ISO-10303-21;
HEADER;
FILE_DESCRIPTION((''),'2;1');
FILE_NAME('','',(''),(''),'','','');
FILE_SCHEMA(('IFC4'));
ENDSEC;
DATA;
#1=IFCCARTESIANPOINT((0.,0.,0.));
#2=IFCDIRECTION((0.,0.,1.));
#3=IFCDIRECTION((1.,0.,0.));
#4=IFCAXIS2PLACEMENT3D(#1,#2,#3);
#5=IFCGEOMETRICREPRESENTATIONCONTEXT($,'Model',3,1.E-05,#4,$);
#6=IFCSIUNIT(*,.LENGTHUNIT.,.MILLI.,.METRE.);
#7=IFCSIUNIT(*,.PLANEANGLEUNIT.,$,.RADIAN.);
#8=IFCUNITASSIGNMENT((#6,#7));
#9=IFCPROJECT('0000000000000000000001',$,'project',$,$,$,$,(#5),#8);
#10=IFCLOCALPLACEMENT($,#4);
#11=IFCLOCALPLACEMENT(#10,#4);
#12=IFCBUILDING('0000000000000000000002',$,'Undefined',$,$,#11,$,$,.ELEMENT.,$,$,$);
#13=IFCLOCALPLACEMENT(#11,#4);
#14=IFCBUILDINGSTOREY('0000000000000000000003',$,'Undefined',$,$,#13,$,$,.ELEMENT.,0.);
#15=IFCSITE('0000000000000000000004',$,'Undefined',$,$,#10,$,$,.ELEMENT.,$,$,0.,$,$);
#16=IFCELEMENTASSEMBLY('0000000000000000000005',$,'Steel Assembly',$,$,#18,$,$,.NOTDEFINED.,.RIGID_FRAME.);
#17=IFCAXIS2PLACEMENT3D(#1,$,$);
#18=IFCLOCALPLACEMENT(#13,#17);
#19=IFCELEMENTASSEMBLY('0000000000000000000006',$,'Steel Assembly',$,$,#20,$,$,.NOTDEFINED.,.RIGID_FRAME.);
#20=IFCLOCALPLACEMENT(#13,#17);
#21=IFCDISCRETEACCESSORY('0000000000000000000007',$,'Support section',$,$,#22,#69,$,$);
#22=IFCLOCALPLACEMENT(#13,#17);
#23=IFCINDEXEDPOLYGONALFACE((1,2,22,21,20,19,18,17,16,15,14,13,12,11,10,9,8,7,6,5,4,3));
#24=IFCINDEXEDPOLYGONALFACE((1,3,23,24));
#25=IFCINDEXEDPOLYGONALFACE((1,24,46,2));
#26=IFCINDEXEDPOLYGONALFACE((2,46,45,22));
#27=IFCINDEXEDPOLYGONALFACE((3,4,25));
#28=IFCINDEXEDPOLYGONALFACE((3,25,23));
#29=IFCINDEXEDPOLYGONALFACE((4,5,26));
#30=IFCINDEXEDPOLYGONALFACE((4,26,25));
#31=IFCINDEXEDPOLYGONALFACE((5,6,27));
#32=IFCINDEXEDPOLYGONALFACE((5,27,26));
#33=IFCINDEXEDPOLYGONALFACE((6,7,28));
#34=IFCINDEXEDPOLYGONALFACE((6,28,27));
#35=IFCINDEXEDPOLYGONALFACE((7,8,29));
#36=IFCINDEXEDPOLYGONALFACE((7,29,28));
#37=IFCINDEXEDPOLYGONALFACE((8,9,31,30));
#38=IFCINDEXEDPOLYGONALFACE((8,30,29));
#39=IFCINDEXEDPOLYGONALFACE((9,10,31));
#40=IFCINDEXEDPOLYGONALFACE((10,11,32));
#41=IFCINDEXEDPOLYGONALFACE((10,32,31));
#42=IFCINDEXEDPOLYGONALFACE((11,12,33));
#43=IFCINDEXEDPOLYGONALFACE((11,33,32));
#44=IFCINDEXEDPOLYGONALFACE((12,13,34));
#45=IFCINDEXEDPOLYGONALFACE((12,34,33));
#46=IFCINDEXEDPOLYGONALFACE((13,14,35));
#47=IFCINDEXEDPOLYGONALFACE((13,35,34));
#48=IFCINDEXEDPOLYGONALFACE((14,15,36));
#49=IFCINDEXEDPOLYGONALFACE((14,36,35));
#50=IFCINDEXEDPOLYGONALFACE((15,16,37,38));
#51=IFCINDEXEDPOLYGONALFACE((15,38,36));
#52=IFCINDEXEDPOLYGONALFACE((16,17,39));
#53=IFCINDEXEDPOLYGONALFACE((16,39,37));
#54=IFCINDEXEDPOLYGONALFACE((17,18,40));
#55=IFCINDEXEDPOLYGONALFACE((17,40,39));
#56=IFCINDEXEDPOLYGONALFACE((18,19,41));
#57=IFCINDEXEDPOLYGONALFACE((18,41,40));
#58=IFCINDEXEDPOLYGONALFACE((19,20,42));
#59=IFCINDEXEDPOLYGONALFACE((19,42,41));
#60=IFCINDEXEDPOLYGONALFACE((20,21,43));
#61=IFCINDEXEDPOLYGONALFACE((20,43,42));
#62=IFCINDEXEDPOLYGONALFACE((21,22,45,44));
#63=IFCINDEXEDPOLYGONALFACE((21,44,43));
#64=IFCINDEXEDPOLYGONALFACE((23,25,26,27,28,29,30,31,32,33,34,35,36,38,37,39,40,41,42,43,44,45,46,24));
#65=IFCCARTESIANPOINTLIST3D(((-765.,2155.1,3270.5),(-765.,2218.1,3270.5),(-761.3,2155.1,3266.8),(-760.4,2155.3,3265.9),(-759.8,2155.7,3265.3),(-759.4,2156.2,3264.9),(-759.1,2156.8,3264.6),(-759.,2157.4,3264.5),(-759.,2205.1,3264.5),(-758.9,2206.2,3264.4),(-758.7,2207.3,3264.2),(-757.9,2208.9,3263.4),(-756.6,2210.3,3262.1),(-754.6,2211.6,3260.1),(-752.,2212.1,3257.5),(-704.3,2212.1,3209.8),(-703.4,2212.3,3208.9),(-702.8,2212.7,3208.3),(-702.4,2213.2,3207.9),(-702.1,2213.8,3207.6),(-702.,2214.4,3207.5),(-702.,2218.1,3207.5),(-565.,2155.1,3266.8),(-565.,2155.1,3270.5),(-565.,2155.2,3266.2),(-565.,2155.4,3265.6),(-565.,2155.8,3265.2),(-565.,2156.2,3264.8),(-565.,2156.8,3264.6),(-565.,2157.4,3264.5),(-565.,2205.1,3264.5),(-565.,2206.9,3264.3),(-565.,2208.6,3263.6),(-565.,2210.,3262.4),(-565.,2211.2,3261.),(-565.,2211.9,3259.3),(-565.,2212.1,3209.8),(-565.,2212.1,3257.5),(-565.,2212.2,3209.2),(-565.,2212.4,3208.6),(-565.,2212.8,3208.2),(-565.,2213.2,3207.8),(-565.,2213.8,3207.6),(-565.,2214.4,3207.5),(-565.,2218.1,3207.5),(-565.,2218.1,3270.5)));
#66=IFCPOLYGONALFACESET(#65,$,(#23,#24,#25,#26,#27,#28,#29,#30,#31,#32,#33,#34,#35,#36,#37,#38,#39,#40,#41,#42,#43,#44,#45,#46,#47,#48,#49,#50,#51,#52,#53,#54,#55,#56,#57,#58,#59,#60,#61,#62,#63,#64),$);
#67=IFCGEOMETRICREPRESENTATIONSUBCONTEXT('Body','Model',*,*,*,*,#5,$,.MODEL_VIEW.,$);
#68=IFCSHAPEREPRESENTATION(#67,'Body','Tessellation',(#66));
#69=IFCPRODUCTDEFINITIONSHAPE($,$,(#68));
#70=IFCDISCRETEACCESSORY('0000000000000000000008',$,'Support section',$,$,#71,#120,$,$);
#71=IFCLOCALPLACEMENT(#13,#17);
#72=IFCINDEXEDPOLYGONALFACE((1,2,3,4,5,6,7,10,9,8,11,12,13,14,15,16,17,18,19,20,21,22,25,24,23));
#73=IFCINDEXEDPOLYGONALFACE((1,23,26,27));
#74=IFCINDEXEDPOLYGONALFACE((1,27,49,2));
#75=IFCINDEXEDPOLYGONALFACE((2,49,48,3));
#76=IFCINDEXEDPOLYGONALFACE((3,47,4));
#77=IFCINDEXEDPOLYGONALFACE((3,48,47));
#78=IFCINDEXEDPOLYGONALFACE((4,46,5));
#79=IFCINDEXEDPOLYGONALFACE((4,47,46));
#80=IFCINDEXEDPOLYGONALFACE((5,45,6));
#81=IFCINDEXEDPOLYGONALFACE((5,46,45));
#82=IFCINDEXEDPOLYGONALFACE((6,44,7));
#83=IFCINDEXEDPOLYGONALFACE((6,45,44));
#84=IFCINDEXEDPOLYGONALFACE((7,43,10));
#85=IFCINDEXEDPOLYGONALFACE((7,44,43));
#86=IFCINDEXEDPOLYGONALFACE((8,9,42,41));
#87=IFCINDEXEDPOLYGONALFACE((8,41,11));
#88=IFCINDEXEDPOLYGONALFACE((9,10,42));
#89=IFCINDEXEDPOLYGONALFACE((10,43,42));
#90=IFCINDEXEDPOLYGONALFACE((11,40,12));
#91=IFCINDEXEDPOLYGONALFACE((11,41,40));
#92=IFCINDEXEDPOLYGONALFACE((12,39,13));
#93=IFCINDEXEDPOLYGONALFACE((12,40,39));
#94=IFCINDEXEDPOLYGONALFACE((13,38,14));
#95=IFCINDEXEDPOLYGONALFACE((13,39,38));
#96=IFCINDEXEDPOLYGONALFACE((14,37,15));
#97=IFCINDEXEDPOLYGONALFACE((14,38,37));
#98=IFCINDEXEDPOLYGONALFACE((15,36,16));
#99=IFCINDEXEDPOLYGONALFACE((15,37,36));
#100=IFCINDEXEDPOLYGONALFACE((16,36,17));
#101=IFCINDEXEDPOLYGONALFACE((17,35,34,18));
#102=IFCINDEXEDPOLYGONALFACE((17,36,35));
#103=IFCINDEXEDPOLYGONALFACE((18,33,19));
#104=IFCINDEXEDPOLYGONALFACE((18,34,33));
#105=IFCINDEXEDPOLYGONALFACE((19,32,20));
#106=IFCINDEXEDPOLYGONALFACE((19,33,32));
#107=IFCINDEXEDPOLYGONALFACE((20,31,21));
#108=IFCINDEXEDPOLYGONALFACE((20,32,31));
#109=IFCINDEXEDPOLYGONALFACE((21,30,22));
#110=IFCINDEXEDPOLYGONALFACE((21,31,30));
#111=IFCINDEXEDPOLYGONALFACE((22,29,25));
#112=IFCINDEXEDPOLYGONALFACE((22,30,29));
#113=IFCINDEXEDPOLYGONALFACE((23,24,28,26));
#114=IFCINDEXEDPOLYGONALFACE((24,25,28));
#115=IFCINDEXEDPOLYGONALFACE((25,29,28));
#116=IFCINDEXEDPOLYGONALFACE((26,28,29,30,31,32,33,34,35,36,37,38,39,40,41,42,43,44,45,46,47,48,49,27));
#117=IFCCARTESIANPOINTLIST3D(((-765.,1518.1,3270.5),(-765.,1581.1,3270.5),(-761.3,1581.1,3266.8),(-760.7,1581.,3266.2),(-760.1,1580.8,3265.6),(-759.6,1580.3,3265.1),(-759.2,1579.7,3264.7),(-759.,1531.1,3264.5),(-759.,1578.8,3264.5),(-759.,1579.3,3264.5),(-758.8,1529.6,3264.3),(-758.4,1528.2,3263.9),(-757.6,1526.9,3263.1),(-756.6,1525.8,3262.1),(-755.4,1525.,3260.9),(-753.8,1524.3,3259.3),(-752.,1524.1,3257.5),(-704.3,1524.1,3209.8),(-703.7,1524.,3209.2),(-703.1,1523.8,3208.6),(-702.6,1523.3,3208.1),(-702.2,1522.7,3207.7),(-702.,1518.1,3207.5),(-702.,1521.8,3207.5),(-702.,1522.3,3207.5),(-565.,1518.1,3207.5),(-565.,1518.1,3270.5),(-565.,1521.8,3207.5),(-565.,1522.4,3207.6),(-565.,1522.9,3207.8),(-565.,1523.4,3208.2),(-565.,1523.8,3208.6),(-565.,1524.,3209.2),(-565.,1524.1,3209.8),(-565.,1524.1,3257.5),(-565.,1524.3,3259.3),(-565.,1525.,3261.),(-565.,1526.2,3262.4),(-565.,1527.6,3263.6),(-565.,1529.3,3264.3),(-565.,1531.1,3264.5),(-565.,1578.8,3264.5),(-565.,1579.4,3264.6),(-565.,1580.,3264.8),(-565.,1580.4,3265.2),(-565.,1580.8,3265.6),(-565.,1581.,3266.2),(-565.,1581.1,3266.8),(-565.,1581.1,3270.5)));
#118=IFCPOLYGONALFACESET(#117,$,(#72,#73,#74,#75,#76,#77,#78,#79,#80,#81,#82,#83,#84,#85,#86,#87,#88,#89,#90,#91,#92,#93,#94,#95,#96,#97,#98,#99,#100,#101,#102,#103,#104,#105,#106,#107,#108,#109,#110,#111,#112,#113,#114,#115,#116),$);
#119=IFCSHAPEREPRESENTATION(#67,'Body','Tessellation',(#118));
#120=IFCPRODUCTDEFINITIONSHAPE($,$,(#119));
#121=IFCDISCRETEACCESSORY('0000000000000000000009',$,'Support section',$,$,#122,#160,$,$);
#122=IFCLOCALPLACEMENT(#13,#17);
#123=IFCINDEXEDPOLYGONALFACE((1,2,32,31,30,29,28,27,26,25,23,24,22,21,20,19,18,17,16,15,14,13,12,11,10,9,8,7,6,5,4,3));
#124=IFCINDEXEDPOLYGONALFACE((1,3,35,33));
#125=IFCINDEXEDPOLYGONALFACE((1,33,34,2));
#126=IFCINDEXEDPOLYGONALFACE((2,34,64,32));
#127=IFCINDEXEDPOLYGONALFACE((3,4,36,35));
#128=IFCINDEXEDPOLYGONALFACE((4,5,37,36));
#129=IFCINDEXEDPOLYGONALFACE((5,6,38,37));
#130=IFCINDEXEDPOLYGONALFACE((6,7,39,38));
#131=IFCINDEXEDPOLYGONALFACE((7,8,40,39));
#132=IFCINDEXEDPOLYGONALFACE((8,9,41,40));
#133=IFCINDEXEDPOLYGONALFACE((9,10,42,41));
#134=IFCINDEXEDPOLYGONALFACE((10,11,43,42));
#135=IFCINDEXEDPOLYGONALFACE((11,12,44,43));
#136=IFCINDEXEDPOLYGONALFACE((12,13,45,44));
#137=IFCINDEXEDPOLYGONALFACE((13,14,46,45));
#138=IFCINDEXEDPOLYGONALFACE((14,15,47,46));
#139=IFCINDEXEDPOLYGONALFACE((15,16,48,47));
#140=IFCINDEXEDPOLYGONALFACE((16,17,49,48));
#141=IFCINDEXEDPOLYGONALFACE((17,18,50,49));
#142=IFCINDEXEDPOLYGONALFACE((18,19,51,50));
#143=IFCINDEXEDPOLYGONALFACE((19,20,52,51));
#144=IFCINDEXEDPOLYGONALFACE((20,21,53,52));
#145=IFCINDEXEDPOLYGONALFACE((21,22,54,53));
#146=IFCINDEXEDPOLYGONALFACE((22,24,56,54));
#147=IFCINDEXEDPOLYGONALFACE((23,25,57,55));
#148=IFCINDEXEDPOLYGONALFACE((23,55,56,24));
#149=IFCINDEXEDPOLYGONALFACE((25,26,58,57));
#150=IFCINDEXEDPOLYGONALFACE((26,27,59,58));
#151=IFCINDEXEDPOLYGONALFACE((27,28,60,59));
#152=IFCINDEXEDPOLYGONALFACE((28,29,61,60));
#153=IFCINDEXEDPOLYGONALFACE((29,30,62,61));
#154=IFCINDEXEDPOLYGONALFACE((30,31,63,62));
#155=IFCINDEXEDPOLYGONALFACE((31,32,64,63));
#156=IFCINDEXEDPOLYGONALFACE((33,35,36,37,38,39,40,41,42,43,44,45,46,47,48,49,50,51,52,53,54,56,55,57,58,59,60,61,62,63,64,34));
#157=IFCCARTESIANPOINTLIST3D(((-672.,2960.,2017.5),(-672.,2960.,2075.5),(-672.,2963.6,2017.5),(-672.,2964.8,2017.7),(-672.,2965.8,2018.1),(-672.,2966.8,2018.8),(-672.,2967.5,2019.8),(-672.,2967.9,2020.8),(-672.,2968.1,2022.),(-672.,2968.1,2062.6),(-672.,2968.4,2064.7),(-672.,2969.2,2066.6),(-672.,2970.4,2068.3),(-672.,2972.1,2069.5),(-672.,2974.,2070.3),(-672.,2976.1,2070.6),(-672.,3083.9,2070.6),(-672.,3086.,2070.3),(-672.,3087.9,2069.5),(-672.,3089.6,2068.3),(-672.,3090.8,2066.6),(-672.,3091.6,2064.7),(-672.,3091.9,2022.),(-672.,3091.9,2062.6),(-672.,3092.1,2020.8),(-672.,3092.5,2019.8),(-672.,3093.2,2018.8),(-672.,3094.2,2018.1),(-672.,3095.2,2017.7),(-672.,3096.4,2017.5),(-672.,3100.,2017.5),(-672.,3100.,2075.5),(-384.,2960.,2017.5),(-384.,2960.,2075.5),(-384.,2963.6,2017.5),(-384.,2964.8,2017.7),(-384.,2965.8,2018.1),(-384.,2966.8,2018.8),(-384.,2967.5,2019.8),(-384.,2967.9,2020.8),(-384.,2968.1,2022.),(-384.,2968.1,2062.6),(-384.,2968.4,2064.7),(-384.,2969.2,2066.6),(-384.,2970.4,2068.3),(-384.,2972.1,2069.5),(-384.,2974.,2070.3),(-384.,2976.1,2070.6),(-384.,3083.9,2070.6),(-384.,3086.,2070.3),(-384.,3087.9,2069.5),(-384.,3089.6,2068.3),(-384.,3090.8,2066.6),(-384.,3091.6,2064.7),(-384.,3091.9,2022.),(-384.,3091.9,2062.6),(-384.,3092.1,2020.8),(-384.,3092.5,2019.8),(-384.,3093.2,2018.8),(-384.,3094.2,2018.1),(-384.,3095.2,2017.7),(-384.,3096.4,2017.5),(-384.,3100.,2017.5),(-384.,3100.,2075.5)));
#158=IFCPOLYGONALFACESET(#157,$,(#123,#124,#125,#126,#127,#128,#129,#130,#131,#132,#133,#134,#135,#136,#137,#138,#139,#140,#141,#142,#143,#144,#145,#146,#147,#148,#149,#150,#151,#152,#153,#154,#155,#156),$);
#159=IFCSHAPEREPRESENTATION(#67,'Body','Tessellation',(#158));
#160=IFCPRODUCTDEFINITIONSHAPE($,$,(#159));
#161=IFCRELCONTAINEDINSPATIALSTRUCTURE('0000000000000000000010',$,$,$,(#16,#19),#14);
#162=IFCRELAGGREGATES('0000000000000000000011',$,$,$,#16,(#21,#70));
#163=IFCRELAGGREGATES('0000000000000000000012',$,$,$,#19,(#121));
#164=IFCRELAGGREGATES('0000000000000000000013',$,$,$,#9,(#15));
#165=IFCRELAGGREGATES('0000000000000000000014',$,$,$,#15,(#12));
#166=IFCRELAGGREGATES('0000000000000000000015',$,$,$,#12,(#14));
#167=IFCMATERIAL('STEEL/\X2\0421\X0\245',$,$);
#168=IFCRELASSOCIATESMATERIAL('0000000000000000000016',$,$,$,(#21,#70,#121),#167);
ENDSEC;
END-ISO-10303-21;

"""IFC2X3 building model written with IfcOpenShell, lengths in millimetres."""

from ifc_helpers import new_model, si_unit, frame, origin_with_axes, origin_2d_with_axis, place, context, subcontext, project, spatial, l_section, u_section, extrude, clip, halfspace, material, element, aggregate, save


model = new_model("IFC2X3")

# Units and contexts
model_context = context("Model", 3, precision=1e-05, world=origin_with_axes())
body_context = subcontext(model_context, "Body", "Model", "MODEL_VIEW")
ifc_project = project(units=[si_unit("LENGTHUNIT", "METRE", prefix="MILLI"), si_unit("PLANEANGLEUNIT", "RADIAN")], contexts=[model_context])

# Site, building, storey
site_placement = place(None, origin_with_axes())
site = spatial("IfcSite", under=ifc_project, at=site_placement, Name="Undefined", CompositionType="ELEMENT", RefElevation=0.0)
building_placement = place(site_placement, origin_with_axes())
building = spatial("IfcBuilding", under=site, at=building_placement, Name="Undefined", CompositionType="ELEMENT")
storey_placement = place(building_placement, origin_with_axes())
storey = spatial("IfcBuildingStorey", under=building, at=storey_placement, Name="Undefined", CompositionType="ELEMENT", Elevation=0.0)

# Shared definitions
ifc_material_1 = material(Name="STEEL/С245")

# Element assembly
assembly_1_placement = place(storey_placement, origin_with_axes())
assembly_1 = element("IfcElementAssembly", 1, at=assembly_1_placement, inside=storey, Name="Steel Assembly", AssemblyPlace="NOTDEFINED", PredefinedType="RIGID_FRAME")

# Element assembly
assembly_2_placement = place(storey_placement, origin_with_axes())
assembly_2 = element("IfcElementAssembly", 2, at=assembly_2_placement, inside=storey, Name="Steel Assembly", AssemblyPlace="NOTDEFINED", PredefinedType="RIGID_FRAME")

# Discrete accessories
discrete_accessory_1_placement = place(assembly_1_placement, frame((-765.0, 2186.6, 3239.0), z_axis=(0.0, -1.0, 0.0), x_axis=(1.0, 0.0, 0.0)))
discrete_accessory_1 = element("IfcDiscreteAccessory", 3, at=discrete_accessory_1_placement, material=ifc_material_1, Name="Support section", context=body_context, shape_type="Clipping", body=[
    clip(extrude(l_section(Depth=63.0, Width=63.0, Thickness=6.0, FilletRadius=7.0, EdgeRadius=2.3, at=origin_2d_with_axis()), frame((200.0, 0.0, 0.0), z_axis=(-1.0, 0.0, 0.0), x_axis=(0.0, -1.0, 0.0)), (0.0, 0.0, 1.0), 200.3), halfspace(frame((63.0, -31.5, -31.5), z_axis=(0.707107, 0.707107, 0.0), x_axis=(0.0, 0.0, 1.0)), True)),
])
discrete_accessory_2_placement = place(assembly_1_placement, frame((-765.0, 1549.6, 3239.0), z_axis=(0.0, 0.0, -1.0), x_axis=(1.0, 0.0, 0.0)))
discrete_accessory_2 = element("IfcDiscreteAccessory", 4, at=discrete_accessory_2_placement, material=ifc_material_1, Name="Support section", context=body_context, shape_type="Clipping", body=[
    clip(extrude(l_section(Depth=63.0, Width=63.0, Thickness=6.0, FilletRadius=7.0, EdgeRadius=2.3, at=origin_2d_with_axis()), frame((200.0, 0.0, 0.0), z_axis=(-1.0, 0.0, 0.0), x_axis=(0.0, -1.0, 0.0)), (0.0, 0.0, 1.0), 200.3), halfspace(frame((63.0, 31.5, 31.5), z_axis=(0.707107, 0.0, -0.707107), x_axis=(0.0, 1.0, 0.0)), True)),
])
aggregate(assembly_1, [discrete_accessory_1, discrete_accessory_2])
discrete_accessory_3_placement = place(assembly_2_placement, frame((-384.0, 3030.0, 2046.5), z_axis=(0.0, 1.0, 0.0), x_axis=(-1.0, 0.0, 0.0)))
discrete_accessory_3 = element("IfcDiscreteAccessory", 5, at=discrete_accessory_3_placement, material=ifc_material_1, Name="Support section", context=body_context, shape_type="SweptSolid", body=[
    extrude(u_section(Depth=140.0, FlangeWidth=58.0, WebThickness=4.9, FlangeThickness=8.1, FilletRadius=8.0, EdgeRadius=4.5, at=origin_2d_with_axis()), frame((288.0, 0.0, 0.0), z_axis=(-1.0, 0.0, 0.0), x_axis=(0.0, -1.0, 0.0)), (0.0, 0.0, 1.0), 288.0),
])

aggregate(assembly_2, [discrete_accessory_3])

save(model, "model.ifc")
